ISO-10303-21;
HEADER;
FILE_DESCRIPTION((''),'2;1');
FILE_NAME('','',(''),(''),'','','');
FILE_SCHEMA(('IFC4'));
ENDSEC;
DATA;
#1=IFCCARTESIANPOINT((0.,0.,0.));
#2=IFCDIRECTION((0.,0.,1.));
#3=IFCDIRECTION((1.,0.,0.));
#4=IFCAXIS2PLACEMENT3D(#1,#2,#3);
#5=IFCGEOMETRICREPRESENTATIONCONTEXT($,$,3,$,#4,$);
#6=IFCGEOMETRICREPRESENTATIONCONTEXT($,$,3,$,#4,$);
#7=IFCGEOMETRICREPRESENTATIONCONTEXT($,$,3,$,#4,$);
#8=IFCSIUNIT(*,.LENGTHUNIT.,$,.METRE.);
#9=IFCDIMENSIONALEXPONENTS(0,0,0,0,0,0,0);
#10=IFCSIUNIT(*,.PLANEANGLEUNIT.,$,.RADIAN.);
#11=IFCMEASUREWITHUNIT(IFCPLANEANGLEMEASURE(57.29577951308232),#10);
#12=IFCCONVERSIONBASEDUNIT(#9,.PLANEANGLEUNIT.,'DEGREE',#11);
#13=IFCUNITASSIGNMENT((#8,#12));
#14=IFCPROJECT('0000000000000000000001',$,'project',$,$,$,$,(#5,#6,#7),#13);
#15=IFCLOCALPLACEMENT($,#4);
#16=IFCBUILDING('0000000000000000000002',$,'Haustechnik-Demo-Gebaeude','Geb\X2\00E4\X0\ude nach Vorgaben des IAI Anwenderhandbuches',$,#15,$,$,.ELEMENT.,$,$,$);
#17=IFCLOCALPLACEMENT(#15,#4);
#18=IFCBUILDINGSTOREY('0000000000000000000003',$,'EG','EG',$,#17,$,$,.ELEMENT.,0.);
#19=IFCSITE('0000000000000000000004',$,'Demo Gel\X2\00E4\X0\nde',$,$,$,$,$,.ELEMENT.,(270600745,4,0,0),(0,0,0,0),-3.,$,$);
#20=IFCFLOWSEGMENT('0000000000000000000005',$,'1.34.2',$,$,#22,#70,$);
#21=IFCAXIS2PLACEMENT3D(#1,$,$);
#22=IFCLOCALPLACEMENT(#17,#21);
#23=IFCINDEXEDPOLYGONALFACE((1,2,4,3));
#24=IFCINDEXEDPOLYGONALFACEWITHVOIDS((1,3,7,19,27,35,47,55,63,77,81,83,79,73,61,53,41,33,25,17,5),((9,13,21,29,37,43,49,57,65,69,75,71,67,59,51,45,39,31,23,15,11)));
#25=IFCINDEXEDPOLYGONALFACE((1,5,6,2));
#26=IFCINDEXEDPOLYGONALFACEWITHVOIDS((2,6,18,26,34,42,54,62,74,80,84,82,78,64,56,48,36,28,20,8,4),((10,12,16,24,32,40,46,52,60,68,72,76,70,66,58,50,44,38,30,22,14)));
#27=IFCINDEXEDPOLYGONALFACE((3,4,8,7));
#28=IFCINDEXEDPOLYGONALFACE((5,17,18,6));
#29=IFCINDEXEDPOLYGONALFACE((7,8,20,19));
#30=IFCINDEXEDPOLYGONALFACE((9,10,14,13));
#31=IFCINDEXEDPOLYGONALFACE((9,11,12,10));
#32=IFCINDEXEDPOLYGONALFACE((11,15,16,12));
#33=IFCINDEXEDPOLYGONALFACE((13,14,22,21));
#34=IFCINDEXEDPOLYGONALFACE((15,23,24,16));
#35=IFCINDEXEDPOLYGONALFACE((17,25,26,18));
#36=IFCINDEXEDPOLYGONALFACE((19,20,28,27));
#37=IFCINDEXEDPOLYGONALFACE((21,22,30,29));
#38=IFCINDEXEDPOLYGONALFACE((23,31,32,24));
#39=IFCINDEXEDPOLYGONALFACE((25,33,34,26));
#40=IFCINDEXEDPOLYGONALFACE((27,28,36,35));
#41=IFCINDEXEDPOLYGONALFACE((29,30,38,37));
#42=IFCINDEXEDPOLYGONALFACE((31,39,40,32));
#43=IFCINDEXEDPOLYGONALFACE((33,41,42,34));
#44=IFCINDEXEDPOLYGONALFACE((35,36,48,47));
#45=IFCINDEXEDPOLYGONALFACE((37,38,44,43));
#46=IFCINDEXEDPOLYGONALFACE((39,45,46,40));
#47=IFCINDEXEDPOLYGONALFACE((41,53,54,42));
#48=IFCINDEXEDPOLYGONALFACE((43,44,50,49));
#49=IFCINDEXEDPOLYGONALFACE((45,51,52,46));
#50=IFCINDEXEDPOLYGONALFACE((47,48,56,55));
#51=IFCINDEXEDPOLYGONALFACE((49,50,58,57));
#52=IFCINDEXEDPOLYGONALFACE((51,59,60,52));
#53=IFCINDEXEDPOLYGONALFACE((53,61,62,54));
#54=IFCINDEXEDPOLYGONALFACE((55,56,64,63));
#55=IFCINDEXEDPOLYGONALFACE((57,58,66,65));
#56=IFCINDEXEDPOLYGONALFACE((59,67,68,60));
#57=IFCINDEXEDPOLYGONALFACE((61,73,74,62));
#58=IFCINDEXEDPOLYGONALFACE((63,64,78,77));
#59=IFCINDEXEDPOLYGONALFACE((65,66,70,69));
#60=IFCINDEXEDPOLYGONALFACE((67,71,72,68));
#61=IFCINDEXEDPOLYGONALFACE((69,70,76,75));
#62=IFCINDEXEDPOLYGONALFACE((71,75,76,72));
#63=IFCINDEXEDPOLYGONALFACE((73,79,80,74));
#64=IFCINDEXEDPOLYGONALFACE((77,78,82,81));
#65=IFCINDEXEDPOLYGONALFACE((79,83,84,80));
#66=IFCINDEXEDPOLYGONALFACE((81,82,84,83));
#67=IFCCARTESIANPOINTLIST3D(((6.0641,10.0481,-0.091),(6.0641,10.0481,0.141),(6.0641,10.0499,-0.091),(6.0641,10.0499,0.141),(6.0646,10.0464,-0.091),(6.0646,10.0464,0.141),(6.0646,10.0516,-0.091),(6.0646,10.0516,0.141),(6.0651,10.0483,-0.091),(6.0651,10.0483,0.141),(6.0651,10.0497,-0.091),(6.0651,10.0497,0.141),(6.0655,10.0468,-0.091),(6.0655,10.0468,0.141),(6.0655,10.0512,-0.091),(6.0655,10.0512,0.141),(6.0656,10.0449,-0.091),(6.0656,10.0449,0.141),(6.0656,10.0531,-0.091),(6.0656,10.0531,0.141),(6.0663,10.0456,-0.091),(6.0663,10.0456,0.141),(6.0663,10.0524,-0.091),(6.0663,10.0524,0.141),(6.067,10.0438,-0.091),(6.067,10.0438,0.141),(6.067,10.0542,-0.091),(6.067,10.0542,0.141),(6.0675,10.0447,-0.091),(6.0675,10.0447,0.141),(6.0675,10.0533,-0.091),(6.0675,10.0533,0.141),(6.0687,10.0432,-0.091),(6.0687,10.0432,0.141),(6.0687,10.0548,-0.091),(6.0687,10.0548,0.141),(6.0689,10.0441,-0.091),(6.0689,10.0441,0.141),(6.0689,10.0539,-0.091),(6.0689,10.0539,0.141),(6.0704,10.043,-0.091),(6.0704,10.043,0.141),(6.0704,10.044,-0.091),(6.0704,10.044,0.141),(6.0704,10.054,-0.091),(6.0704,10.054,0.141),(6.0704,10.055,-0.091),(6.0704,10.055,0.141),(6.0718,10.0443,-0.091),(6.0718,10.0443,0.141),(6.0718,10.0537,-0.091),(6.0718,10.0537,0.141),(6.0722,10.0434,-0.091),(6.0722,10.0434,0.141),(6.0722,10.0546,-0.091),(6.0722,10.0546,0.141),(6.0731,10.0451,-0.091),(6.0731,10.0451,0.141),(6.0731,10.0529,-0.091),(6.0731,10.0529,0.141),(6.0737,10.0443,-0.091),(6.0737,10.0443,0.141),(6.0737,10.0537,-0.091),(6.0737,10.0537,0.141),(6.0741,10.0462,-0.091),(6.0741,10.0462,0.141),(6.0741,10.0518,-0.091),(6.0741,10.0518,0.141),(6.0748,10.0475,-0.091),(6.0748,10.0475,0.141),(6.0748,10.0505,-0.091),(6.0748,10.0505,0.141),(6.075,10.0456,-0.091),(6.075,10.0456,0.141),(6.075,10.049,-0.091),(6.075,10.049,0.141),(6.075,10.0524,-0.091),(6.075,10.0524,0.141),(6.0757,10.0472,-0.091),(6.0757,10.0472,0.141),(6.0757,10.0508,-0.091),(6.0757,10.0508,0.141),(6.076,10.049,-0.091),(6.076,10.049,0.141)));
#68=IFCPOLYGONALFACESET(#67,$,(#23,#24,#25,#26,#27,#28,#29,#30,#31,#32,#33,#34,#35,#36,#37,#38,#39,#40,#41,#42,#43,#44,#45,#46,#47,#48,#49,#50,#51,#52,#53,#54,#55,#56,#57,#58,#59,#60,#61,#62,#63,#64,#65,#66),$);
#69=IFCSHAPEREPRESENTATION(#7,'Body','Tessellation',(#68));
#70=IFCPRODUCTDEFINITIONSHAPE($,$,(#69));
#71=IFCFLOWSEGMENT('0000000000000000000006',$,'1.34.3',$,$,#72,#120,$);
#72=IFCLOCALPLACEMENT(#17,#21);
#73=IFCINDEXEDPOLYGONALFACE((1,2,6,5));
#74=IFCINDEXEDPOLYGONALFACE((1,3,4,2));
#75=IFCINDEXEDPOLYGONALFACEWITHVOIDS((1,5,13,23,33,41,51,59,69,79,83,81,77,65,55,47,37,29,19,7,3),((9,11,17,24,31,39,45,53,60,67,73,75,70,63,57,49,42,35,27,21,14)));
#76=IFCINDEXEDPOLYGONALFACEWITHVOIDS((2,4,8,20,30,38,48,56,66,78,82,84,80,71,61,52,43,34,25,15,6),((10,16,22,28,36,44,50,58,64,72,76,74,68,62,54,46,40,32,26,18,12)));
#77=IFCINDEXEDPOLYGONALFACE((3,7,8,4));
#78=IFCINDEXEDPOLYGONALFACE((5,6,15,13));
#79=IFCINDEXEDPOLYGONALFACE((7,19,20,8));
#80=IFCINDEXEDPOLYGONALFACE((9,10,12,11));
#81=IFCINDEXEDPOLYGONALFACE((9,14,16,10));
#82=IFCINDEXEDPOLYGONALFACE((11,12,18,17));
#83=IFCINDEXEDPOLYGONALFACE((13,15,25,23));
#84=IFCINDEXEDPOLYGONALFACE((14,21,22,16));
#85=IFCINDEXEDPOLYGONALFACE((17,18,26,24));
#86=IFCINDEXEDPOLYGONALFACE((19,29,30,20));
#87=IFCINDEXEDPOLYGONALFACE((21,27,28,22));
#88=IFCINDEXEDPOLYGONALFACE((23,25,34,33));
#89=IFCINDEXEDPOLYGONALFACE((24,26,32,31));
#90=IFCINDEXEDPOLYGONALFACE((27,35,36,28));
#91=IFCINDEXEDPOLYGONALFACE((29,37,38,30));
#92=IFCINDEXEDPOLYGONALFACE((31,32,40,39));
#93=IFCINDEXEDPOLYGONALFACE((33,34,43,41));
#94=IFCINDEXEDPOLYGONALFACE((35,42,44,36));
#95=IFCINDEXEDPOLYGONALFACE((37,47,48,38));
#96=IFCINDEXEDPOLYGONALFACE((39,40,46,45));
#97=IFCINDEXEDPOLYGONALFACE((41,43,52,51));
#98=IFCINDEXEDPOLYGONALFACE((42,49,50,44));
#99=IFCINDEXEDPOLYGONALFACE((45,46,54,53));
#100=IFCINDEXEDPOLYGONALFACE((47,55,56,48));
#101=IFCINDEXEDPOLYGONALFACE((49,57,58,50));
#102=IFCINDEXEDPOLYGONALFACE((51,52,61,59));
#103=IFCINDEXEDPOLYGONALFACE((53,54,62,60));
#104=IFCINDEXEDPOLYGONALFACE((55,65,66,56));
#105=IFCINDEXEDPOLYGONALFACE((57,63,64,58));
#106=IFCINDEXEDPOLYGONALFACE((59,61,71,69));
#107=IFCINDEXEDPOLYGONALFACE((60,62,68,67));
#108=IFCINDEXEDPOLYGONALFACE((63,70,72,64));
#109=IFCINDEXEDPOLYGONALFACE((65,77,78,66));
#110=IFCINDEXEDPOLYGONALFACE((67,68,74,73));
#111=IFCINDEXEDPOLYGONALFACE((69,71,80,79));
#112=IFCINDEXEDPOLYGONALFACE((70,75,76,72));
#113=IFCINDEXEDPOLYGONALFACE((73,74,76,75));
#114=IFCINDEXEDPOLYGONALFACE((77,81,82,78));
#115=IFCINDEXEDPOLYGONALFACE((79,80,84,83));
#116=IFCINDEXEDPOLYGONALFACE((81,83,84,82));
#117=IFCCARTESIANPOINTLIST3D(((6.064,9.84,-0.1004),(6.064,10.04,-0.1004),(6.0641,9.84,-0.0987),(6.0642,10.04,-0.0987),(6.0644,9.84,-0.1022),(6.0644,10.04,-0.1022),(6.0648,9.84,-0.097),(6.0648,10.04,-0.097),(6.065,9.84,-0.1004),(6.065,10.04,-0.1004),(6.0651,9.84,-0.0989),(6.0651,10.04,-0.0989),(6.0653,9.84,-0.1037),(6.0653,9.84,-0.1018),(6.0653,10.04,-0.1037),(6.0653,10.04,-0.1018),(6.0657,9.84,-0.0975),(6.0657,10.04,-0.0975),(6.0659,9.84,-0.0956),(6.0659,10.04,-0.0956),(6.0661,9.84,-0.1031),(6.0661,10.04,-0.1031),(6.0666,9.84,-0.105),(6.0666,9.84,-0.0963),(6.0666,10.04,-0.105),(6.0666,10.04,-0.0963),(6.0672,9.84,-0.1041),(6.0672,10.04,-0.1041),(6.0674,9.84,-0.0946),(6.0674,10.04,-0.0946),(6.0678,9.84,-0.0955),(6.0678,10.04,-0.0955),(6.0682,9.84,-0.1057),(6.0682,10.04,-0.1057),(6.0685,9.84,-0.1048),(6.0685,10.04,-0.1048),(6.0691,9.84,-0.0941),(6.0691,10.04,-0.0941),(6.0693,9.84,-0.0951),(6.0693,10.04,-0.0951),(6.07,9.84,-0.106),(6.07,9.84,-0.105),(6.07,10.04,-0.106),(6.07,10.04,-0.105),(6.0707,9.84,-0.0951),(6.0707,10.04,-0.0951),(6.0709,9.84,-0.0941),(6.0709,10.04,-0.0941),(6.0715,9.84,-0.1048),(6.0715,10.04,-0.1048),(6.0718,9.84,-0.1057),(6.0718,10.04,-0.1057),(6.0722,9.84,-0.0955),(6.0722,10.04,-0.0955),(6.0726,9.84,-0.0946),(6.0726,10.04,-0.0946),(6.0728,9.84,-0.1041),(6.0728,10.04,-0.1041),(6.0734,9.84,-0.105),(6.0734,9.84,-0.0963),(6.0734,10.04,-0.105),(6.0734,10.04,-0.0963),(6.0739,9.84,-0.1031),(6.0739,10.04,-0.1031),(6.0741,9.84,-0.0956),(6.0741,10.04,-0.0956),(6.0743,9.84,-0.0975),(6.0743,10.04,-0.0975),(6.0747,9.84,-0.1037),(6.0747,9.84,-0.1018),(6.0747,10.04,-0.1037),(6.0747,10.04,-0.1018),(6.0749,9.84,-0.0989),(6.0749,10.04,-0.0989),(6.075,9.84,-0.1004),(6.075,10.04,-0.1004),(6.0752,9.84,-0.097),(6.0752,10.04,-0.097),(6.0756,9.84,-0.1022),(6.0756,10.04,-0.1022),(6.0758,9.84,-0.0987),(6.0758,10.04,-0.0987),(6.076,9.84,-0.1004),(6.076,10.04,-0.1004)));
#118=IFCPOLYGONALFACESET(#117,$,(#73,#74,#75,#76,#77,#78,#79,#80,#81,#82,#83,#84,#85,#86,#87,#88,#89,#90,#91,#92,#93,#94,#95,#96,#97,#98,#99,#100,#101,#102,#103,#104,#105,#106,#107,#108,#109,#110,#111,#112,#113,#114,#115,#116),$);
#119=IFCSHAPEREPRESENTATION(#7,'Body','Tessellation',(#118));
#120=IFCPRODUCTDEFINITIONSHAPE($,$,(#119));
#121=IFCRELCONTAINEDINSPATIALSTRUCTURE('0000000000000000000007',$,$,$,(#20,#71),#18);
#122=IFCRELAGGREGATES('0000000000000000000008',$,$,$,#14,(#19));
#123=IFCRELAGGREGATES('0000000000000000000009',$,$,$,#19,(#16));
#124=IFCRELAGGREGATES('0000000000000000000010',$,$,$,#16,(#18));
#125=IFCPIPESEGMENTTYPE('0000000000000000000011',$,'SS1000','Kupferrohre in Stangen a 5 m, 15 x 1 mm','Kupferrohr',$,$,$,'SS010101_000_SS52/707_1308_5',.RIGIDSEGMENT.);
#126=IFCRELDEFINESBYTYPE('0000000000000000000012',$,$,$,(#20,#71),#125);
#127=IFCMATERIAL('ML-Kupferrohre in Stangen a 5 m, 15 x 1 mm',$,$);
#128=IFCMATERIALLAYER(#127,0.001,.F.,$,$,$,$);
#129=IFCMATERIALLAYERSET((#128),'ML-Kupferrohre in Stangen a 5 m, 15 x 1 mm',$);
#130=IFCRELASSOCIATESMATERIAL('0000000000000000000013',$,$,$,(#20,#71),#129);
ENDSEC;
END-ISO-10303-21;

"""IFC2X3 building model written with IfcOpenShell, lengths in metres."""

from ifc_helpers import new_model, entity, si_unit, converted_unit, frame, origin_with_axes, origin_2d_with_axis, place, context, project, spatial, hollow_circle, extrude, material, layer, layer_set, layer_usage, type_object, element, save


model = new_model("IFC2X3")

# Units and contexts
context_of_model_1 = context(None, 3, world=origin_with_axes())
context_of_model_2 = context(None, 3, world=origin_with_axes())
context_of_model_3 = context(None, 3, world=origin_with_axes())
ifc_project = project(units=[si_unit("LENGTHUNIT", "METRE"), converted_unit("PLANEANGLEUNIT", "DEGREE", entity("IfcPlaneAngleMeasure", 57.29577951308232), si_unit("PLANEANGLEUNIT", "RADIAN"), dimensions=[0, 0, 0, 0, 0, 0, 0])], contexts=[context_of_model_1, context_of_model_2, context_of_model_3])

# Site, building, storey
site = spatial("IfcSite", under=ifc_project, Name="Demo Gelände", CompositionType="ELEMENT", RefLatitude=(270600745, 4, 0, 0), RefLongitude=(0, 0, 0, 0), RefElevation=-3.0)
building_placement = place(None, origin_with_axes())
building = spatial("IfcBuilding", under=site, at=building_placement, Name="Haustechnik-Demo-Gebaeude", Description="Gebäude nach Vorgaben des IAI Anwenderhandbuches", CompositionType="ELEMENT")
storey_placement = place(building_placement, origin_with_axes())
storey = spatial("IfcBuildingStorey", under=building, at=storey_placement, Name="EG", Description="EG", CompositionType="ELEMENT", Elevation=0.0)

# Flow segments
ifc_material_1 = material(Name="ML-Kupferrohre in Stangen a 5 m, 15 x 1 mm")
ifc_layer_1 = layer(ifc_material_1, 0.001, ventilated=False)
ifc_layer_set_1 = layer_set([ifc_layer_1], Name="ML-Kupferrohre in Stangen a 5 m, 15 x 1 mm")
ifc_layer_usage_1 = layer_usage(ifc_layer_set_1, "AXIS2", "POSITIVE", 0.0)
pipe_segment_type_1 = type_object("IfcPipeSegmentType", Name="SS1000", Description="Kupferrohre in Stangen a 5 m, 15 x 1 mm", ApplicableOccurrence="Kupferrohr", ElementType="SS010101_000_SS52/707_1308_5", PredefinedType="RIGIDSEGMENT")
flow_segment_1_placement = place(storey_placement, frame((6.07, 10.049, 0.141), z_axis=(0.0, 0.0, -1.0), x_axis=(1.0, 0.0, 0.0)))
element("IfcFlowSegment", 1, at=flow_segment_1_placement, inside=storey, type_object=pipe_segment_type_1, material=ifc_layer_usage_1, Name="1.34.2", context=context_of_model_3, shape_type="SweptSolid", body=[
    extrude(hollow_circle(Radius=0.006, WallThickness=0.001, at=origin_2d_with_axis()), origin_with_axes(), (0.0, 0.0, 1.0), 0.232),
])
flow_segment_2_placement = place(storey_placement, frame((6.07, 10.04, -0.1), z_axis=(-0.000001, -1.0, 0.0), x_axis=(0.0, 0.0, -1.0)))
element("IfcFlowSegment", 2, at=flow_segment_2_placement, inside=storey, type_object=pipe_segment_type_1, material=ifc_layer_usage_1, Name="1.34.3", context=context_of_model_3, shape_type="SweptSolid", body=[
    extrude(hollow_circle(Radius=0.006, WallThickness=0.001, at=origin_2d_with_axis()), origin_with_axes(), (0.0, 0.0, 1.0), 0.2),
])

save(model, "model.ifc")
